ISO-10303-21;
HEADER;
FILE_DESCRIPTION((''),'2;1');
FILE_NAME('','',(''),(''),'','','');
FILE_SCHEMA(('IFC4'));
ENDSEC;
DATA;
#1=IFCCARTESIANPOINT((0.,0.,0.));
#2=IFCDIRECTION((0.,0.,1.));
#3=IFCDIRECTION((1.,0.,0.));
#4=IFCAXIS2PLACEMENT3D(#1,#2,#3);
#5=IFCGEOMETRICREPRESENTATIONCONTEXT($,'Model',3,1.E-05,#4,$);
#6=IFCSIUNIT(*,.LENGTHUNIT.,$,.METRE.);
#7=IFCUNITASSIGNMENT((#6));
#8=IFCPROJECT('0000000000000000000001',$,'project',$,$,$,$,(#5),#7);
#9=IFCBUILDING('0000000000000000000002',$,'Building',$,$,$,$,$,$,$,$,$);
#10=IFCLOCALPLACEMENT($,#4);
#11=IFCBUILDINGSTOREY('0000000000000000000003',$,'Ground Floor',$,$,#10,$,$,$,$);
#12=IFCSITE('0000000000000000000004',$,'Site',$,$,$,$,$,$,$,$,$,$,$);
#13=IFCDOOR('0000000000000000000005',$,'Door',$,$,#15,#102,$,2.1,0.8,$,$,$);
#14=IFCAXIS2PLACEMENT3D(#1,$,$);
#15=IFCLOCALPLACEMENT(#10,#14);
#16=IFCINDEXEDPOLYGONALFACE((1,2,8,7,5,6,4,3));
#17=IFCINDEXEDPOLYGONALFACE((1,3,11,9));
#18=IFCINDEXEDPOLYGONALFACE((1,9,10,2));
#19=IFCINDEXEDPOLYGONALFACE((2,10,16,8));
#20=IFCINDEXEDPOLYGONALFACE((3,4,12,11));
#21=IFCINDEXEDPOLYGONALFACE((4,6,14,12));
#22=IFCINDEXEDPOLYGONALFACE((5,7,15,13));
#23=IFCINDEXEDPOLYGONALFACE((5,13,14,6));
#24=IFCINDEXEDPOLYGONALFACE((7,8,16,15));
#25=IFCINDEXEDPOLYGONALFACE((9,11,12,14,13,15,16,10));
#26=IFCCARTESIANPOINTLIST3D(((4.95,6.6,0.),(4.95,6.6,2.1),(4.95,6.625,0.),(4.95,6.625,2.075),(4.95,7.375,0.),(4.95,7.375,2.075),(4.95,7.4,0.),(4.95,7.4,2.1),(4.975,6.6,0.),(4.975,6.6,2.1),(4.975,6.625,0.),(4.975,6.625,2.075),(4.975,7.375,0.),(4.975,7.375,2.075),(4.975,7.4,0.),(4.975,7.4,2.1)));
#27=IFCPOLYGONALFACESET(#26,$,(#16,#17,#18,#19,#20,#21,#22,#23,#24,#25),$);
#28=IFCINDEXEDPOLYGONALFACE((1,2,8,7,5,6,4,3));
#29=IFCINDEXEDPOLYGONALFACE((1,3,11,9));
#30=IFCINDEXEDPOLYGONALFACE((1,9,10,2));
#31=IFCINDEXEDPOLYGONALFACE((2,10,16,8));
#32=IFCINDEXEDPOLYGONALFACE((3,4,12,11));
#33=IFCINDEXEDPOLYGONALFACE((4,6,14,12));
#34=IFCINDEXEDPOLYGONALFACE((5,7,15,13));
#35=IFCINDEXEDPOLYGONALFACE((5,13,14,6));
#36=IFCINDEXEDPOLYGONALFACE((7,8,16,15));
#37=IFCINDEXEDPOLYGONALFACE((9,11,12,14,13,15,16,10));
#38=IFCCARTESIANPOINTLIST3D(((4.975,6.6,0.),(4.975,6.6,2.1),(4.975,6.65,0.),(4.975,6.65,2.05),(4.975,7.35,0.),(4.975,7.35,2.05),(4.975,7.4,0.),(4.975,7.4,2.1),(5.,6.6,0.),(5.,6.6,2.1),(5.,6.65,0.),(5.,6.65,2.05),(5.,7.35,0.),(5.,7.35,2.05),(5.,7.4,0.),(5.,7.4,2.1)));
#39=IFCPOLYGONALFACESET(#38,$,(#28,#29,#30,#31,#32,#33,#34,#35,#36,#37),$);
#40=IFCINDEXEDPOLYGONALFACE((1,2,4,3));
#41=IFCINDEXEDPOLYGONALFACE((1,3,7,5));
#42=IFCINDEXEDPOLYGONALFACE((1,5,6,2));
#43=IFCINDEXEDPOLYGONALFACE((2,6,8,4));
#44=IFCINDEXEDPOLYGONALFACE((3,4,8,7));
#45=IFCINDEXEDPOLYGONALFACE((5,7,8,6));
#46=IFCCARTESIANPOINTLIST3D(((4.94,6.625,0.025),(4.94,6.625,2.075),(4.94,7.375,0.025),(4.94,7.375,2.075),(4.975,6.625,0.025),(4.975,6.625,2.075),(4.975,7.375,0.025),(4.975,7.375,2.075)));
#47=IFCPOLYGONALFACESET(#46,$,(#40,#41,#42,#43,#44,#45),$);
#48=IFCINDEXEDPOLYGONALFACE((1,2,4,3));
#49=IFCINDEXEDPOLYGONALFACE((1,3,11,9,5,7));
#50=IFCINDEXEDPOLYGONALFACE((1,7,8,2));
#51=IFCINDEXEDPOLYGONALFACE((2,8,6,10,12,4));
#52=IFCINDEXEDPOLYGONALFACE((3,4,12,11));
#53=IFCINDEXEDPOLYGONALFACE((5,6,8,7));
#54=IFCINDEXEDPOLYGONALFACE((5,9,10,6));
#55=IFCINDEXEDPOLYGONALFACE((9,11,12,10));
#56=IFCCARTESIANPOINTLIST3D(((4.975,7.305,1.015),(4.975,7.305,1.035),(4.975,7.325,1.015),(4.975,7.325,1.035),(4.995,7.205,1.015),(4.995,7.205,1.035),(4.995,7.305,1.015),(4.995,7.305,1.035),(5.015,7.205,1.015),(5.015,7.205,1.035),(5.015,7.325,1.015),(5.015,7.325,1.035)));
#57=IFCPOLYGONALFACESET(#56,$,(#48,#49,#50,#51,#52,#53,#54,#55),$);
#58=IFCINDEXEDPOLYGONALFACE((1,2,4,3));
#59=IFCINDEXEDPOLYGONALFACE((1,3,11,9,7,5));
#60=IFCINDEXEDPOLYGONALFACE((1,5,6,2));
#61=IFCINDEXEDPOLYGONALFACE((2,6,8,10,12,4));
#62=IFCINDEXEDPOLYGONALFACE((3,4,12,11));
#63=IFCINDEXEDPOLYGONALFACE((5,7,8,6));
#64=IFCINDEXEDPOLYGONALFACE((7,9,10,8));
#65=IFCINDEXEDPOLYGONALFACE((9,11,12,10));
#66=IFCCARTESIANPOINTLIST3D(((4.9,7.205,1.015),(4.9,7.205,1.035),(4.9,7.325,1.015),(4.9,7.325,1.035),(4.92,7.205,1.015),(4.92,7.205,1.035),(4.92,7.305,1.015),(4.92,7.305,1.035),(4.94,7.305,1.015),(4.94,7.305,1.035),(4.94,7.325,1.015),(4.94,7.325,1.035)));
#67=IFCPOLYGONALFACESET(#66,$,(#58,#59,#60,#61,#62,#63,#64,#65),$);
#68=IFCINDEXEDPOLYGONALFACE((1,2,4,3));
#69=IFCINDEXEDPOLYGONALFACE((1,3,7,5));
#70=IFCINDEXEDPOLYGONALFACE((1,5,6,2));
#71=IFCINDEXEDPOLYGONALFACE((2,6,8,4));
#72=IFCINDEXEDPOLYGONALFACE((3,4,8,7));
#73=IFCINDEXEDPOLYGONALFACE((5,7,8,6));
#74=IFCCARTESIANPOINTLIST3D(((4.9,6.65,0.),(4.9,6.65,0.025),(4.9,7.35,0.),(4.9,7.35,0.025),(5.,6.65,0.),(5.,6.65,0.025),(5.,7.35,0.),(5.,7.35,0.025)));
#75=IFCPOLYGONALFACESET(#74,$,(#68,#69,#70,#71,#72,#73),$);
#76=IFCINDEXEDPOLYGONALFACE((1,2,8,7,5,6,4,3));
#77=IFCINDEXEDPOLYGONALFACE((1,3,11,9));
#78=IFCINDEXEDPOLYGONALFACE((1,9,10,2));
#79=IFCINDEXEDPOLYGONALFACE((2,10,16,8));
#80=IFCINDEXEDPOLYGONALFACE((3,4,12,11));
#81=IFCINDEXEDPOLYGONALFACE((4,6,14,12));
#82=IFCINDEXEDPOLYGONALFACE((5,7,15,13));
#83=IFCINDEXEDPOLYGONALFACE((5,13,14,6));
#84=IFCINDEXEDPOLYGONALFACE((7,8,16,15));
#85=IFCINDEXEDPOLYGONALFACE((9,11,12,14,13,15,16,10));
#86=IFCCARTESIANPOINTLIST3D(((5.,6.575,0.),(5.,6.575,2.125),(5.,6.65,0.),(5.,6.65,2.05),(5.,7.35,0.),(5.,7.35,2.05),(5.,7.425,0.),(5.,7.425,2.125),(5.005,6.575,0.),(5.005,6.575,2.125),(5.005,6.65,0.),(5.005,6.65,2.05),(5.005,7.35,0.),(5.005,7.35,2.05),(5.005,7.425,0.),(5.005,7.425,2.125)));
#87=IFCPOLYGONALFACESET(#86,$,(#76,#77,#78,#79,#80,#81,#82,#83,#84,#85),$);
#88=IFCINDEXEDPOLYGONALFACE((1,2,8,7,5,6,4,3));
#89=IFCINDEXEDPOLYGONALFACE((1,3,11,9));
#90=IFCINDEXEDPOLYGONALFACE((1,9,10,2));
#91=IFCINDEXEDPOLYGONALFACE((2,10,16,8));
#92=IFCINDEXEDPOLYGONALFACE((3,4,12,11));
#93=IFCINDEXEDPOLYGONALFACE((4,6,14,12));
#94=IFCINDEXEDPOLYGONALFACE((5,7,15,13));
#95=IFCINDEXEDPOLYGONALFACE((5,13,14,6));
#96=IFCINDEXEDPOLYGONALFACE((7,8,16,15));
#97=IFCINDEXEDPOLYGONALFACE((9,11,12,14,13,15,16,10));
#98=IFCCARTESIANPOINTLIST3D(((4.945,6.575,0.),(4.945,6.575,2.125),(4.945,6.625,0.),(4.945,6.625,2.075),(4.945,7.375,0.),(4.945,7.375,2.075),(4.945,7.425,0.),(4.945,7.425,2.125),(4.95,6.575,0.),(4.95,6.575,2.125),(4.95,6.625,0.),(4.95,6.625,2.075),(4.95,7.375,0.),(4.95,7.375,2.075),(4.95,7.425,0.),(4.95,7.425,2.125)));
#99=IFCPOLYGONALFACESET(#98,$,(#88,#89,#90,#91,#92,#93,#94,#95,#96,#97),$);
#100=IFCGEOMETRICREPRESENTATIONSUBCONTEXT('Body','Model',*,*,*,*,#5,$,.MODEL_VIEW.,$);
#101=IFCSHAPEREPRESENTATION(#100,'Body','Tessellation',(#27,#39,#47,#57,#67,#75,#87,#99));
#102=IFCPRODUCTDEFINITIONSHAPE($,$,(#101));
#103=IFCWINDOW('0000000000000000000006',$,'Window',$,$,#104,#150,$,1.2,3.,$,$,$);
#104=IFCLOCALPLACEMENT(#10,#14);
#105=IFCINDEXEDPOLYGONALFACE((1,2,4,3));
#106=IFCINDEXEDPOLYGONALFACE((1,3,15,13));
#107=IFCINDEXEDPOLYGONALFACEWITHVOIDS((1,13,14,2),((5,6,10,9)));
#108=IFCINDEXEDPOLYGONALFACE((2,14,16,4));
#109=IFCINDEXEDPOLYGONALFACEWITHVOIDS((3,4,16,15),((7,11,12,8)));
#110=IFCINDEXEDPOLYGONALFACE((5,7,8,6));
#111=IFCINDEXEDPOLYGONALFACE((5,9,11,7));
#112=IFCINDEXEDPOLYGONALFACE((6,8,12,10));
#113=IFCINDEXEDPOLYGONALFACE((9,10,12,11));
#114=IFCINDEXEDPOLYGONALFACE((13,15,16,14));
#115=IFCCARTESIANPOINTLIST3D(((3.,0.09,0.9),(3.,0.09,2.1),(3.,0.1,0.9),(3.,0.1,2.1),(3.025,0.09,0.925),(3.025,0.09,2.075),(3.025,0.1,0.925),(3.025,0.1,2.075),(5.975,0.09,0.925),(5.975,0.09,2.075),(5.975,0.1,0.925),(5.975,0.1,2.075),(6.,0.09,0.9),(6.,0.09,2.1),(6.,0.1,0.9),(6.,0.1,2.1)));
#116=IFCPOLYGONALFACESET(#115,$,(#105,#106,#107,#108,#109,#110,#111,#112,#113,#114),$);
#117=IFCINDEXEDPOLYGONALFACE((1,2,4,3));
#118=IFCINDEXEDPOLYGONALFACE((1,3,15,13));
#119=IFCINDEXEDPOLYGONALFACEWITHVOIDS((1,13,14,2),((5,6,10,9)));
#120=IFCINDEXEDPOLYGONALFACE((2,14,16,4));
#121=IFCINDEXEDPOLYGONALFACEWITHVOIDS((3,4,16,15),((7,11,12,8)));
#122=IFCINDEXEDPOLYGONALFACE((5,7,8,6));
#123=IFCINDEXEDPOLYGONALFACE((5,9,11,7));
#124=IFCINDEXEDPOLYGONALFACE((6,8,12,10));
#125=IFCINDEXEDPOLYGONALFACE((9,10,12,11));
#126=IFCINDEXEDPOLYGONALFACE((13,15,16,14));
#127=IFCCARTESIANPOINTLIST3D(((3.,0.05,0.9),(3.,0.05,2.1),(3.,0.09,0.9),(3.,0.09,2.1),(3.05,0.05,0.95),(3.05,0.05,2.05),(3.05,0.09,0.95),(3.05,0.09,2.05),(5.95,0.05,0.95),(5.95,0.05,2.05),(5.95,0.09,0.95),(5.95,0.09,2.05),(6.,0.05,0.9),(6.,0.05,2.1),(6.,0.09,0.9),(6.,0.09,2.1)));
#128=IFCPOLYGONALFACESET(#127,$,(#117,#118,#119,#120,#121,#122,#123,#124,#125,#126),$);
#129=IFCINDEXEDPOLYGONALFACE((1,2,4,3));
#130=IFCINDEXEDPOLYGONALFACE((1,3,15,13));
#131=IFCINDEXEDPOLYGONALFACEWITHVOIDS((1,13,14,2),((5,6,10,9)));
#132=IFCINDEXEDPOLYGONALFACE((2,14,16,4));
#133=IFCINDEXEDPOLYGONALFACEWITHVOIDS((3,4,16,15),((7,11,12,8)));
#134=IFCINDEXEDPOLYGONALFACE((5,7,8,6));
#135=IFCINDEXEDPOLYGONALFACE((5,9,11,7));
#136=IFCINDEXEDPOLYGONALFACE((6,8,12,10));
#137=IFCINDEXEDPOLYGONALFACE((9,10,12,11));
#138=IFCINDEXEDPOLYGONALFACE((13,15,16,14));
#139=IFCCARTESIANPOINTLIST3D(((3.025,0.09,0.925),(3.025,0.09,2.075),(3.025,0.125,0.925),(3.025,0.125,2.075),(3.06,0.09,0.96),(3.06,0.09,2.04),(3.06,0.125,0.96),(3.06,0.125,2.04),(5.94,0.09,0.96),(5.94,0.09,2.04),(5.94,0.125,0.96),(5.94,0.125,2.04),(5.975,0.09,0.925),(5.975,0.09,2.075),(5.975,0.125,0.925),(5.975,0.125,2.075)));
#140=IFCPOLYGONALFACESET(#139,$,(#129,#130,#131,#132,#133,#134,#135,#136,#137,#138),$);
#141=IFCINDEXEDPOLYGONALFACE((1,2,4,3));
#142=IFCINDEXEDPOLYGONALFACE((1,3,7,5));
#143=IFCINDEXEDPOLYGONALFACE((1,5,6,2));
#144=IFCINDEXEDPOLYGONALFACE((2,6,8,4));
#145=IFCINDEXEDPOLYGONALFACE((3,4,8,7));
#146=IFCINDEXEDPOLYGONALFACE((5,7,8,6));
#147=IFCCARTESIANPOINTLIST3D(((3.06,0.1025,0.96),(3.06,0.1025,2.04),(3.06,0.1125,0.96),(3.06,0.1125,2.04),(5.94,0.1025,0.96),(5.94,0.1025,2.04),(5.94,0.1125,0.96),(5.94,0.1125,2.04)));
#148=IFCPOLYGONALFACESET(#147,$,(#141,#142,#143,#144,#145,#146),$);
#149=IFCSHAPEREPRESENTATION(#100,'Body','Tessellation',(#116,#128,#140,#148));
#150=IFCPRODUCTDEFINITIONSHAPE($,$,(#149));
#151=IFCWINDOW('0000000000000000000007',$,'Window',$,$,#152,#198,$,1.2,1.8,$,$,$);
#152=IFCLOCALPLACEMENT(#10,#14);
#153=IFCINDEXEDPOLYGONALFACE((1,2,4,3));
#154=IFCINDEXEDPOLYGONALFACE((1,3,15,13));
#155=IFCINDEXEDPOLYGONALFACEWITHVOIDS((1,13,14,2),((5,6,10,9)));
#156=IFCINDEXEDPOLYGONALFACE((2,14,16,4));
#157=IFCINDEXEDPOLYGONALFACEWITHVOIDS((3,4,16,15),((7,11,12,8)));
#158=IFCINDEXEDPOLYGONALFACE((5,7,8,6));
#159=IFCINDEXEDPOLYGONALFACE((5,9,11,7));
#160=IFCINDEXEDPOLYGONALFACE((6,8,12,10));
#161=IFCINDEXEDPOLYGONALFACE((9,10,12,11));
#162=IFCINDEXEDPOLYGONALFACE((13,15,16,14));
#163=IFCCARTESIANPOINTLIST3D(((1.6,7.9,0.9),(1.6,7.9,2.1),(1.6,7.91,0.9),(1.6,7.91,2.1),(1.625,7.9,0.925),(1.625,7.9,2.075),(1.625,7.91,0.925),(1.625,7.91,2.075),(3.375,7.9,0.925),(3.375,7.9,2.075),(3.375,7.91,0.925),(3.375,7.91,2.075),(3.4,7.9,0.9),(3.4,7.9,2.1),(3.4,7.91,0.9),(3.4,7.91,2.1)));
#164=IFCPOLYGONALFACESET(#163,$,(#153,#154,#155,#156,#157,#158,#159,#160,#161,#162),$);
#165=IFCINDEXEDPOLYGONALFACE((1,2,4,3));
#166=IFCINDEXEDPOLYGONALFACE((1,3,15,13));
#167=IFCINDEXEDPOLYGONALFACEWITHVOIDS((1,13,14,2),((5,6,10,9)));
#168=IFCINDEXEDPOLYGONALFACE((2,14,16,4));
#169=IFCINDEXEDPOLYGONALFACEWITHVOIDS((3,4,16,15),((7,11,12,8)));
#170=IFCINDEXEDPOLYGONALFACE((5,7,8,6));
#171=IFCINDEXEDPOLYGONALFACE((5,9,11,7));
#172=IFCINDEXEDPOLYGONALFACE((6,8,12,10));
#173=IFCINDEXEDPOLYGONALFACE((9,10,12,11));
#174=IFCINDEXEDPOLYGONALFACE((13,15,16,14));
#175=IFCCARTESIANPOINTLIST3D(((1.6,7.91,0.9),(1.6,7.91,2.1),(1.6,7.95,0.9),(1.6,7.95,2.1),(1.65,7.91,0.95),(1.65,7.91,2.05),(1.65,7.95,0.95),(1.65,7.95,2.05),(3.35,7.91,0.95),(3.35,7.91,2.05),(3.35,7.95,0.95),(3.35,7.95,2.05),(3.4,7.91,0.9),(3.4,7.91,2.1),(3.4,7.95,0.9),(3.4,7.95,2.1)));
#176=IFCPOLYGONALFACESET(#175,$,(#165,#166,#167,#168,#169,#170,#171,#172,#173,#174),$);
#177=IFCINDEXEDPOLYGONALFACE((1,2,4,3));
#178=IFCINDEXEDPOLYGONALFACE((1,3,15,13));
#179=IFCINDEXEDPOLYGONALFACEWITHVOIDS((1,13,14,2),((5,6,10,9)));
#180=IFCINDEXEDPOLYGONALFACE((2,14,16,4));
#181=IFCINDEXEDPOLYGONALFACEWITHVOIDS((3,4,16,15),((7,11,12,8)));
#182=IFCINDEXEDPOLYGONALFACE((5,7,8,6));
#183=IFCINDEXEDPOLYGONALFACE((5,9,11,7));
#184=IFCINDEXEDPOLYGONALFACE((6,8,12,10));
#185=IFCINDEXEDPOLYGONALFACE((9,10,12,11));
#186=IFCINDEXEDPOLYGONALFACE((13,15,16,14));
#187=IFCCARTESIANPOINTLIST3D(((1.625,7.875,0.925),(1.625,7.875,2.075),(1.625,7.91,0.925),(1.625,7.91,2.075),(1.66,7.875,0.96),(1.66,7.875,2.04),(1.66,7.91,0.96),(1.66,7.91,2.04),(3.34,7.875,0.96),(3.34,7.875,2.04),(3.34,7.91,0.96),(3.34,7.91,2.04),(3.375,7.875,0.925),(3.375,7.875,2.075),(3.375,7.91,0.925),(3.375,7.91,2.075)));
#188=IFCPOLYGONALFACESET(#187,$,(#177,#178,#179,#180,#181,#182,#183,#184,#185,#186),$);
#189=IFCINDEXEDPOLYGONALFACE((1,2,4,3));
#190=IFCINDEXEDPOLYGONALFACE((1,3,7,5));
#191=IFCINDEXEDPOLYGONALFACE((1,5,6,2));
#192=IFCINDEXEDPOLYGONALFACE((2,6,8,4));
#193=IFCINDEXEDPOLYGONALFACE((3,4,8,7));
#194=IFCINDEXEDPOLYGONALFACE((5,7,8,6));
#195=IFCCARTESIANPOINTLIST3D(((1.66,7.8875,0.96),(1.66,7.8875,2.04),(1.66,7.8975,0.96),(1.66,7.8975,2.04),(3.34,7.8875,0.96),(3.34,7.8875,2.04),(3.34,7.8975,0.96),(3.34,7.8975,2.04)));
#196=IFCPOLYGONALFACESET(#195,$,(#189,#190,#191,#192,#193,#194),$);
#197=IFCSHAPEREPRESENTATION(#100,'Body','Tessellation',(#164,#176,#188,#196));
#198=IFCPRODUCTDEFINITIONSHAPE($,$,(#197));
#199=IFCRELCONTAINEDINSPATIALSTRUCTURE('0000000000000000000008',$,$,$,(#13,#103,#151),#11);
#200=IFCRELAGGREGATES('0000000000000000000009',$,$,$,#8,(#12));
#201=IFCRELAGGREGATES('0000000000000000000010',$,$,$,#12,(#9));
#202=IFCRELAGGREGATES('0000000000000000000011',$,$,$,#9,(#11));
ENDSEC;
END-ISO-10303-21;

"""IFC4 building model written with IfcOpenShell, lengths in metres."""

from ifc_helpers import new_model, si_unit, frame, origin_with_axes, place, context, subcontext, project, spatial, line, indexed_curve, outline, extrude, element, save


model = new_model("IFC4")

# Units and contexts
model_context = context("Model", 3, precision=1e-05, world=origin_with_axes())
body_context = subcontext(model_context, "Body", "Model", "MODEL_VIEW")
ifc_project = project(units=[si_unit("LENGTHUNIT", "METRE")], contexts=[model_context])

# Site, building, storey
site = spatial("IfcSite", under=ifc_project, Name="Site")
building = spatial("IfcBuilding", under=site, Name="Building")
storey_placement = place(None, origin_with_axes())
storey = spatial("IfcBuildingStorey", under=building, at=storey_placement, Name="Ground Floor")

# Door
door_1_placement = place(storey_placement, frame((5.0, 6.6, 0.0), z_axis=(0.0, 0.0, 1.0), x_axis=(0.0, 1.0, 0.0)))
element("IfcDoor", 1, at=door_1_placement, inside=storey, Name="Door", OverallHeight=2.1, OverallWidth=0.8, context=body_context, shape_type="SweptSolid", body=[
    extrude(outline(indexed_curve([(0.0, 0.0), (0.0, 2.1), (0.8, 2.1), (0.8, 0.0), (0.775, 0.0), (0.775, 2.075), (0.025, 2.075), (0.025, 0.0)], segments=[line(1, 2, 3, 4, 5, 6, 7, 8, 1)])), frame((0.0, 0.025, 0.0), z_axis=(0.0, -1.0, 0.0), x_axis=(1.0, 0.0, 0.0)), (0.0, 0.0, -1.0), 0.025),
    extrude(outline(indexed_curve([(0.0, 0.0), (0.0, 2.1), (0.8, 2.1), (0.8, 0.0), (0.75, 0.0), (0.75, 2.05), (0.05, 2.05), (0.05, 0.0)], segments=[line(1, 2, 3, 4, 5, 6, 7, 8, 1)])), frame((0.0, 0.0, 0.0), z_axis=(0.0, -1.0, 0.0), x_axis=(1.0, 0.0, 0.0)), (0.0, 0.0, -1.0), 0.025),
    extrude(outline(indexed_curve([(0.0, 0.0), (0.75, 0.0), (0.75, 0.035), (0.0, 0.035)], segments=[line(1, 2, 3, 4, 1)])), frame((0.025, 0.025, 0.025), z_axis=(0.0, 0.0, 1.0), x_axis=(1.0, 0.0, 0.0)), (0.0, 0.0, 1.0), 2.05),
    extrude(outline(indexed_curve([(0.0, 0.0), (0.0, -0.04), (-0.12, -0.04), (-0.12, -0.02), (-0.02, -0.02), (-0.02, 0.0)], segments=[line(1, 2, 3, 4, 5, 6, 1)])), frame((0.725, 0.025, 1.015), z_axis=(0.0, 0.0, 1.0), x_axis=(1.0, 0.0, 0.0)), (0.0, 0.0, 1.0), 0.02),
    extrude(outline(indexed_curve([(0.0, 0.0), (0.0, 0.04), (-0.12, 0.04), (-0.12, 0.02), (-0.02, 0.02), (-0.02, 0.0)], segments=[line(1, 2, 3, 4, 5, 6, 1)])), frame((0.725, 0.06, 1.015), z_axis=(0.0, 0.0, 1.0), x_axis=(1.0, 0.0, 0.0)), (0.0, 0.0, 1.0), 0.02),
    extrude(outline(indexed_curve([(0.0, 0.0), (0.7, 0.0), (0.7, 0.1), (0.0, 0.1)], segments=[line(1, 2, 3, 4, 1)])), frame((0.05, 0.0, 0.0), z_axis=(0.0, 0.0, 1.0), x_axis=(1.0, 0.0, 0.0)), (0.0, 0.0, 1.0), 0.025),
    extrude(outline(indexed_curve([(0.0, 0.0), (0.0, 2.125), (0.85, 2.125), (0.85, 0.0), (0.775, 0.0), (0.775, 2.05), (0.075, 2.05), (0.075, 0.0)], segments=[line(1, 2, 3, 4, 5, 6, 7, 8, 1)])), frame((-0.025, -0.005, 0.0), z_axis=(0.0, -1.0, 0.0), x_axis=(1.0, 0.0, 0.0)), (0.0, 0.0, -1.0), 0.005),
    extrude(outline(indexed_curve([(0.0, 0.0), (0.0, 2.125), (0.85, 2.125), (0.85, 0.0), (0.8, 0.0), (0.8, 2.075), (0.05, 2.075), (0.05, 0.0)], segments=[line(1, 2, 3, 4, 5, 6, 7, 8, 1)])), frame((-0.025, 0.05, 0.0), z_axis=(0.0, -1.0, 0.0), x_axis=(1.0, 0.0, 0.0)), (0.0, 0.0, -1.0), 0.005),
])

# Windows
window_1_placement = place(storey_placement, frame((3.0, 0.0, 0.9), z_axis=(0.0, 0.0, 1.0), x_axis=(1.0, 0.0, 0.0)))
element("IfcWindow", 2, at=window_1_placement, inside=storey, Name="Window", OverallHeight=1.2, OverallWidth=3.0, context=body_context, shape_type="SweptSolid", body=[
    extrude(outline(indexed_curve([(0.0, 0.0), (3.0, 0.0), (3.0, 1.2), (0.0, 1.2)], segments=[line(1, 2, 3, 4, 1)]), holes=[indexed_curve([(0.025, 0.025), (2.975, 0.025), (2.975, 1.175), (0.025, 1.175)], segments=[line(1, 2, 3, 4, 1)])]), frame((0.0, 0.09, 0.0), z_axis=(0.0, -1.0, 0.0), x_axis=(1.0, 0.0, 0.0)), (0.0, 0.0, -1.0), 0.01),
    extrude(outline(indexed_curve([(0.0, 0.0), (3.0, 0.0), (3.0, 1.2), (0.0, 1.2)], segments=[line(1, 2, 3, 4, 1)]), holes=[indexed_curve([(0.05, 0.05), (2.95, 0.05), (2.95, 1.15), (0.05, 1.15)], segments=[line(1, 2, 3, 4, 1)])]), frame((0.0, 0.05, 0.0), z_axis=(0.0, -1.0, 0.0), x_axis=(1.0, 0.0, 0.0)), (0.0, 0.0, -1.0), 0.04),
    extrude(outline(indexed_curve([(0.0, 0.0), (2.95, 0.0), (2.95, 1.15), (0.0, 1.15)], segments=[line(1, 2, 3, 4, 1)]), holes=[indexed_curve([(0.035, 0.035), (2.915, 0.035), (2.915, 1.115), (0.035, 1.115)], segments=[line(1, 2, 3, 4, 1)])]), frame((0.025, 0.09, 0.025), z_axis=(0.0, -1.0, 0.0), x_axis=(1.0, 0.0, 0.0)), (0.0, 0.0, -1.0), 0.035),
    extrude(outline(indexed_curve([(0.035, 0.035), (2.915, 0.035), (2.915, 1.115), (0.035, 1.115)], segments=[line(1, 2, 3, 4, 1)])), frame((0.025, 0.1025, 0.025), z_axis=(0.0, -1.0, 0.0), x_axis=(1.0, 0.0, 0.0)), (0.0, 0.0, -1.0), 0.01),
])
window_2_placement = place(storey_placement, frame((3.4, 8.0, 0.9), z_axis=(0.0, 0.0, 1.0), x_axis=(-1.0, 0.0, 0.0)))
element("IfcWindow", 3, at=window_2_placement, inside=storey, Name="Window", OverallHeight=1.2, OverallWidth=1.8, context=body_context, shape_type="SweptSolid", body=[
    extrude(outline(indexed_curve([(0.0, 0.0), (1.8, 0.0), (1.8, 1.2), (0.0, 1.2)], segments=[line(1, 2, 3, 4, 1)]), holes=[indexed_curve([(0.025, 0.025), (1.775, 0.025), (1.775, 1.175), (0.025, 1.175)], segments=[line(1, 2, 3, 4, 1)])]), frame((0.0, 0.09, 0.0), z_axis=(0.0, -1.0, 0.0), x_axis=(1.0, 0.0, 0.0)), (0.0, 0.0, -1.0), 0.01),
    extrude(outline(indexed_curve([(0.0, 0.0), (1.8, 0.0), (1.8, 1.2), (0.0, 1.2)], segments=[line(1, 2, 3, 4, 1)]), holes=[indexed_curve([(0.05, 0.05), (1.75, 0.05), (1.75, 1.15), (0.05, 1.15)], segments=[line(1, 2, 3, 4, 1)])]), frame((0.0, 0.05, 0.0), z_axis=(0.0, -1.0, 0.0), x_axis=(1.0, 0.0, 0.0)), (0.0, 0.0, -1.0), 0.04),
    extrude(outline(indexed_curve([(0.0, 0.0), (1.75, 0.0), (1.75, 1.15), (0.0, 1.15)], segments=[line(1, 2, 3, 4, 1)]), holes=[indexed_curve([(0.035, 0.035), (1.715, 0.035), (1.715, 1.115), (0.035, 1.115)], segments=[line(1, 2, 3, 4, 1)])]), frame((0.025, 0.09, 0.025), z_axis=(0.0, -1.0, 0.0), x_axis=(1.0, 0.0, 0.0)), (0.0, 0.0, -1.0), 0.035),
    extrude(outline(indexed_curve([(0.035, 0.035), (1.715, 0.035), (1.715, 1.115), (0.035, 1.115)], segments=[line(1, 2, 3, 4, 1)])), frame((0.025, 0.1025, 0.025), z_axis=(0.0, -1.0, 0.0), x_axis=(1.0, 0.0, 0.0)), (0.0, 0.0, -1.0), 0.01),
])

save(model, "model.ifc")
